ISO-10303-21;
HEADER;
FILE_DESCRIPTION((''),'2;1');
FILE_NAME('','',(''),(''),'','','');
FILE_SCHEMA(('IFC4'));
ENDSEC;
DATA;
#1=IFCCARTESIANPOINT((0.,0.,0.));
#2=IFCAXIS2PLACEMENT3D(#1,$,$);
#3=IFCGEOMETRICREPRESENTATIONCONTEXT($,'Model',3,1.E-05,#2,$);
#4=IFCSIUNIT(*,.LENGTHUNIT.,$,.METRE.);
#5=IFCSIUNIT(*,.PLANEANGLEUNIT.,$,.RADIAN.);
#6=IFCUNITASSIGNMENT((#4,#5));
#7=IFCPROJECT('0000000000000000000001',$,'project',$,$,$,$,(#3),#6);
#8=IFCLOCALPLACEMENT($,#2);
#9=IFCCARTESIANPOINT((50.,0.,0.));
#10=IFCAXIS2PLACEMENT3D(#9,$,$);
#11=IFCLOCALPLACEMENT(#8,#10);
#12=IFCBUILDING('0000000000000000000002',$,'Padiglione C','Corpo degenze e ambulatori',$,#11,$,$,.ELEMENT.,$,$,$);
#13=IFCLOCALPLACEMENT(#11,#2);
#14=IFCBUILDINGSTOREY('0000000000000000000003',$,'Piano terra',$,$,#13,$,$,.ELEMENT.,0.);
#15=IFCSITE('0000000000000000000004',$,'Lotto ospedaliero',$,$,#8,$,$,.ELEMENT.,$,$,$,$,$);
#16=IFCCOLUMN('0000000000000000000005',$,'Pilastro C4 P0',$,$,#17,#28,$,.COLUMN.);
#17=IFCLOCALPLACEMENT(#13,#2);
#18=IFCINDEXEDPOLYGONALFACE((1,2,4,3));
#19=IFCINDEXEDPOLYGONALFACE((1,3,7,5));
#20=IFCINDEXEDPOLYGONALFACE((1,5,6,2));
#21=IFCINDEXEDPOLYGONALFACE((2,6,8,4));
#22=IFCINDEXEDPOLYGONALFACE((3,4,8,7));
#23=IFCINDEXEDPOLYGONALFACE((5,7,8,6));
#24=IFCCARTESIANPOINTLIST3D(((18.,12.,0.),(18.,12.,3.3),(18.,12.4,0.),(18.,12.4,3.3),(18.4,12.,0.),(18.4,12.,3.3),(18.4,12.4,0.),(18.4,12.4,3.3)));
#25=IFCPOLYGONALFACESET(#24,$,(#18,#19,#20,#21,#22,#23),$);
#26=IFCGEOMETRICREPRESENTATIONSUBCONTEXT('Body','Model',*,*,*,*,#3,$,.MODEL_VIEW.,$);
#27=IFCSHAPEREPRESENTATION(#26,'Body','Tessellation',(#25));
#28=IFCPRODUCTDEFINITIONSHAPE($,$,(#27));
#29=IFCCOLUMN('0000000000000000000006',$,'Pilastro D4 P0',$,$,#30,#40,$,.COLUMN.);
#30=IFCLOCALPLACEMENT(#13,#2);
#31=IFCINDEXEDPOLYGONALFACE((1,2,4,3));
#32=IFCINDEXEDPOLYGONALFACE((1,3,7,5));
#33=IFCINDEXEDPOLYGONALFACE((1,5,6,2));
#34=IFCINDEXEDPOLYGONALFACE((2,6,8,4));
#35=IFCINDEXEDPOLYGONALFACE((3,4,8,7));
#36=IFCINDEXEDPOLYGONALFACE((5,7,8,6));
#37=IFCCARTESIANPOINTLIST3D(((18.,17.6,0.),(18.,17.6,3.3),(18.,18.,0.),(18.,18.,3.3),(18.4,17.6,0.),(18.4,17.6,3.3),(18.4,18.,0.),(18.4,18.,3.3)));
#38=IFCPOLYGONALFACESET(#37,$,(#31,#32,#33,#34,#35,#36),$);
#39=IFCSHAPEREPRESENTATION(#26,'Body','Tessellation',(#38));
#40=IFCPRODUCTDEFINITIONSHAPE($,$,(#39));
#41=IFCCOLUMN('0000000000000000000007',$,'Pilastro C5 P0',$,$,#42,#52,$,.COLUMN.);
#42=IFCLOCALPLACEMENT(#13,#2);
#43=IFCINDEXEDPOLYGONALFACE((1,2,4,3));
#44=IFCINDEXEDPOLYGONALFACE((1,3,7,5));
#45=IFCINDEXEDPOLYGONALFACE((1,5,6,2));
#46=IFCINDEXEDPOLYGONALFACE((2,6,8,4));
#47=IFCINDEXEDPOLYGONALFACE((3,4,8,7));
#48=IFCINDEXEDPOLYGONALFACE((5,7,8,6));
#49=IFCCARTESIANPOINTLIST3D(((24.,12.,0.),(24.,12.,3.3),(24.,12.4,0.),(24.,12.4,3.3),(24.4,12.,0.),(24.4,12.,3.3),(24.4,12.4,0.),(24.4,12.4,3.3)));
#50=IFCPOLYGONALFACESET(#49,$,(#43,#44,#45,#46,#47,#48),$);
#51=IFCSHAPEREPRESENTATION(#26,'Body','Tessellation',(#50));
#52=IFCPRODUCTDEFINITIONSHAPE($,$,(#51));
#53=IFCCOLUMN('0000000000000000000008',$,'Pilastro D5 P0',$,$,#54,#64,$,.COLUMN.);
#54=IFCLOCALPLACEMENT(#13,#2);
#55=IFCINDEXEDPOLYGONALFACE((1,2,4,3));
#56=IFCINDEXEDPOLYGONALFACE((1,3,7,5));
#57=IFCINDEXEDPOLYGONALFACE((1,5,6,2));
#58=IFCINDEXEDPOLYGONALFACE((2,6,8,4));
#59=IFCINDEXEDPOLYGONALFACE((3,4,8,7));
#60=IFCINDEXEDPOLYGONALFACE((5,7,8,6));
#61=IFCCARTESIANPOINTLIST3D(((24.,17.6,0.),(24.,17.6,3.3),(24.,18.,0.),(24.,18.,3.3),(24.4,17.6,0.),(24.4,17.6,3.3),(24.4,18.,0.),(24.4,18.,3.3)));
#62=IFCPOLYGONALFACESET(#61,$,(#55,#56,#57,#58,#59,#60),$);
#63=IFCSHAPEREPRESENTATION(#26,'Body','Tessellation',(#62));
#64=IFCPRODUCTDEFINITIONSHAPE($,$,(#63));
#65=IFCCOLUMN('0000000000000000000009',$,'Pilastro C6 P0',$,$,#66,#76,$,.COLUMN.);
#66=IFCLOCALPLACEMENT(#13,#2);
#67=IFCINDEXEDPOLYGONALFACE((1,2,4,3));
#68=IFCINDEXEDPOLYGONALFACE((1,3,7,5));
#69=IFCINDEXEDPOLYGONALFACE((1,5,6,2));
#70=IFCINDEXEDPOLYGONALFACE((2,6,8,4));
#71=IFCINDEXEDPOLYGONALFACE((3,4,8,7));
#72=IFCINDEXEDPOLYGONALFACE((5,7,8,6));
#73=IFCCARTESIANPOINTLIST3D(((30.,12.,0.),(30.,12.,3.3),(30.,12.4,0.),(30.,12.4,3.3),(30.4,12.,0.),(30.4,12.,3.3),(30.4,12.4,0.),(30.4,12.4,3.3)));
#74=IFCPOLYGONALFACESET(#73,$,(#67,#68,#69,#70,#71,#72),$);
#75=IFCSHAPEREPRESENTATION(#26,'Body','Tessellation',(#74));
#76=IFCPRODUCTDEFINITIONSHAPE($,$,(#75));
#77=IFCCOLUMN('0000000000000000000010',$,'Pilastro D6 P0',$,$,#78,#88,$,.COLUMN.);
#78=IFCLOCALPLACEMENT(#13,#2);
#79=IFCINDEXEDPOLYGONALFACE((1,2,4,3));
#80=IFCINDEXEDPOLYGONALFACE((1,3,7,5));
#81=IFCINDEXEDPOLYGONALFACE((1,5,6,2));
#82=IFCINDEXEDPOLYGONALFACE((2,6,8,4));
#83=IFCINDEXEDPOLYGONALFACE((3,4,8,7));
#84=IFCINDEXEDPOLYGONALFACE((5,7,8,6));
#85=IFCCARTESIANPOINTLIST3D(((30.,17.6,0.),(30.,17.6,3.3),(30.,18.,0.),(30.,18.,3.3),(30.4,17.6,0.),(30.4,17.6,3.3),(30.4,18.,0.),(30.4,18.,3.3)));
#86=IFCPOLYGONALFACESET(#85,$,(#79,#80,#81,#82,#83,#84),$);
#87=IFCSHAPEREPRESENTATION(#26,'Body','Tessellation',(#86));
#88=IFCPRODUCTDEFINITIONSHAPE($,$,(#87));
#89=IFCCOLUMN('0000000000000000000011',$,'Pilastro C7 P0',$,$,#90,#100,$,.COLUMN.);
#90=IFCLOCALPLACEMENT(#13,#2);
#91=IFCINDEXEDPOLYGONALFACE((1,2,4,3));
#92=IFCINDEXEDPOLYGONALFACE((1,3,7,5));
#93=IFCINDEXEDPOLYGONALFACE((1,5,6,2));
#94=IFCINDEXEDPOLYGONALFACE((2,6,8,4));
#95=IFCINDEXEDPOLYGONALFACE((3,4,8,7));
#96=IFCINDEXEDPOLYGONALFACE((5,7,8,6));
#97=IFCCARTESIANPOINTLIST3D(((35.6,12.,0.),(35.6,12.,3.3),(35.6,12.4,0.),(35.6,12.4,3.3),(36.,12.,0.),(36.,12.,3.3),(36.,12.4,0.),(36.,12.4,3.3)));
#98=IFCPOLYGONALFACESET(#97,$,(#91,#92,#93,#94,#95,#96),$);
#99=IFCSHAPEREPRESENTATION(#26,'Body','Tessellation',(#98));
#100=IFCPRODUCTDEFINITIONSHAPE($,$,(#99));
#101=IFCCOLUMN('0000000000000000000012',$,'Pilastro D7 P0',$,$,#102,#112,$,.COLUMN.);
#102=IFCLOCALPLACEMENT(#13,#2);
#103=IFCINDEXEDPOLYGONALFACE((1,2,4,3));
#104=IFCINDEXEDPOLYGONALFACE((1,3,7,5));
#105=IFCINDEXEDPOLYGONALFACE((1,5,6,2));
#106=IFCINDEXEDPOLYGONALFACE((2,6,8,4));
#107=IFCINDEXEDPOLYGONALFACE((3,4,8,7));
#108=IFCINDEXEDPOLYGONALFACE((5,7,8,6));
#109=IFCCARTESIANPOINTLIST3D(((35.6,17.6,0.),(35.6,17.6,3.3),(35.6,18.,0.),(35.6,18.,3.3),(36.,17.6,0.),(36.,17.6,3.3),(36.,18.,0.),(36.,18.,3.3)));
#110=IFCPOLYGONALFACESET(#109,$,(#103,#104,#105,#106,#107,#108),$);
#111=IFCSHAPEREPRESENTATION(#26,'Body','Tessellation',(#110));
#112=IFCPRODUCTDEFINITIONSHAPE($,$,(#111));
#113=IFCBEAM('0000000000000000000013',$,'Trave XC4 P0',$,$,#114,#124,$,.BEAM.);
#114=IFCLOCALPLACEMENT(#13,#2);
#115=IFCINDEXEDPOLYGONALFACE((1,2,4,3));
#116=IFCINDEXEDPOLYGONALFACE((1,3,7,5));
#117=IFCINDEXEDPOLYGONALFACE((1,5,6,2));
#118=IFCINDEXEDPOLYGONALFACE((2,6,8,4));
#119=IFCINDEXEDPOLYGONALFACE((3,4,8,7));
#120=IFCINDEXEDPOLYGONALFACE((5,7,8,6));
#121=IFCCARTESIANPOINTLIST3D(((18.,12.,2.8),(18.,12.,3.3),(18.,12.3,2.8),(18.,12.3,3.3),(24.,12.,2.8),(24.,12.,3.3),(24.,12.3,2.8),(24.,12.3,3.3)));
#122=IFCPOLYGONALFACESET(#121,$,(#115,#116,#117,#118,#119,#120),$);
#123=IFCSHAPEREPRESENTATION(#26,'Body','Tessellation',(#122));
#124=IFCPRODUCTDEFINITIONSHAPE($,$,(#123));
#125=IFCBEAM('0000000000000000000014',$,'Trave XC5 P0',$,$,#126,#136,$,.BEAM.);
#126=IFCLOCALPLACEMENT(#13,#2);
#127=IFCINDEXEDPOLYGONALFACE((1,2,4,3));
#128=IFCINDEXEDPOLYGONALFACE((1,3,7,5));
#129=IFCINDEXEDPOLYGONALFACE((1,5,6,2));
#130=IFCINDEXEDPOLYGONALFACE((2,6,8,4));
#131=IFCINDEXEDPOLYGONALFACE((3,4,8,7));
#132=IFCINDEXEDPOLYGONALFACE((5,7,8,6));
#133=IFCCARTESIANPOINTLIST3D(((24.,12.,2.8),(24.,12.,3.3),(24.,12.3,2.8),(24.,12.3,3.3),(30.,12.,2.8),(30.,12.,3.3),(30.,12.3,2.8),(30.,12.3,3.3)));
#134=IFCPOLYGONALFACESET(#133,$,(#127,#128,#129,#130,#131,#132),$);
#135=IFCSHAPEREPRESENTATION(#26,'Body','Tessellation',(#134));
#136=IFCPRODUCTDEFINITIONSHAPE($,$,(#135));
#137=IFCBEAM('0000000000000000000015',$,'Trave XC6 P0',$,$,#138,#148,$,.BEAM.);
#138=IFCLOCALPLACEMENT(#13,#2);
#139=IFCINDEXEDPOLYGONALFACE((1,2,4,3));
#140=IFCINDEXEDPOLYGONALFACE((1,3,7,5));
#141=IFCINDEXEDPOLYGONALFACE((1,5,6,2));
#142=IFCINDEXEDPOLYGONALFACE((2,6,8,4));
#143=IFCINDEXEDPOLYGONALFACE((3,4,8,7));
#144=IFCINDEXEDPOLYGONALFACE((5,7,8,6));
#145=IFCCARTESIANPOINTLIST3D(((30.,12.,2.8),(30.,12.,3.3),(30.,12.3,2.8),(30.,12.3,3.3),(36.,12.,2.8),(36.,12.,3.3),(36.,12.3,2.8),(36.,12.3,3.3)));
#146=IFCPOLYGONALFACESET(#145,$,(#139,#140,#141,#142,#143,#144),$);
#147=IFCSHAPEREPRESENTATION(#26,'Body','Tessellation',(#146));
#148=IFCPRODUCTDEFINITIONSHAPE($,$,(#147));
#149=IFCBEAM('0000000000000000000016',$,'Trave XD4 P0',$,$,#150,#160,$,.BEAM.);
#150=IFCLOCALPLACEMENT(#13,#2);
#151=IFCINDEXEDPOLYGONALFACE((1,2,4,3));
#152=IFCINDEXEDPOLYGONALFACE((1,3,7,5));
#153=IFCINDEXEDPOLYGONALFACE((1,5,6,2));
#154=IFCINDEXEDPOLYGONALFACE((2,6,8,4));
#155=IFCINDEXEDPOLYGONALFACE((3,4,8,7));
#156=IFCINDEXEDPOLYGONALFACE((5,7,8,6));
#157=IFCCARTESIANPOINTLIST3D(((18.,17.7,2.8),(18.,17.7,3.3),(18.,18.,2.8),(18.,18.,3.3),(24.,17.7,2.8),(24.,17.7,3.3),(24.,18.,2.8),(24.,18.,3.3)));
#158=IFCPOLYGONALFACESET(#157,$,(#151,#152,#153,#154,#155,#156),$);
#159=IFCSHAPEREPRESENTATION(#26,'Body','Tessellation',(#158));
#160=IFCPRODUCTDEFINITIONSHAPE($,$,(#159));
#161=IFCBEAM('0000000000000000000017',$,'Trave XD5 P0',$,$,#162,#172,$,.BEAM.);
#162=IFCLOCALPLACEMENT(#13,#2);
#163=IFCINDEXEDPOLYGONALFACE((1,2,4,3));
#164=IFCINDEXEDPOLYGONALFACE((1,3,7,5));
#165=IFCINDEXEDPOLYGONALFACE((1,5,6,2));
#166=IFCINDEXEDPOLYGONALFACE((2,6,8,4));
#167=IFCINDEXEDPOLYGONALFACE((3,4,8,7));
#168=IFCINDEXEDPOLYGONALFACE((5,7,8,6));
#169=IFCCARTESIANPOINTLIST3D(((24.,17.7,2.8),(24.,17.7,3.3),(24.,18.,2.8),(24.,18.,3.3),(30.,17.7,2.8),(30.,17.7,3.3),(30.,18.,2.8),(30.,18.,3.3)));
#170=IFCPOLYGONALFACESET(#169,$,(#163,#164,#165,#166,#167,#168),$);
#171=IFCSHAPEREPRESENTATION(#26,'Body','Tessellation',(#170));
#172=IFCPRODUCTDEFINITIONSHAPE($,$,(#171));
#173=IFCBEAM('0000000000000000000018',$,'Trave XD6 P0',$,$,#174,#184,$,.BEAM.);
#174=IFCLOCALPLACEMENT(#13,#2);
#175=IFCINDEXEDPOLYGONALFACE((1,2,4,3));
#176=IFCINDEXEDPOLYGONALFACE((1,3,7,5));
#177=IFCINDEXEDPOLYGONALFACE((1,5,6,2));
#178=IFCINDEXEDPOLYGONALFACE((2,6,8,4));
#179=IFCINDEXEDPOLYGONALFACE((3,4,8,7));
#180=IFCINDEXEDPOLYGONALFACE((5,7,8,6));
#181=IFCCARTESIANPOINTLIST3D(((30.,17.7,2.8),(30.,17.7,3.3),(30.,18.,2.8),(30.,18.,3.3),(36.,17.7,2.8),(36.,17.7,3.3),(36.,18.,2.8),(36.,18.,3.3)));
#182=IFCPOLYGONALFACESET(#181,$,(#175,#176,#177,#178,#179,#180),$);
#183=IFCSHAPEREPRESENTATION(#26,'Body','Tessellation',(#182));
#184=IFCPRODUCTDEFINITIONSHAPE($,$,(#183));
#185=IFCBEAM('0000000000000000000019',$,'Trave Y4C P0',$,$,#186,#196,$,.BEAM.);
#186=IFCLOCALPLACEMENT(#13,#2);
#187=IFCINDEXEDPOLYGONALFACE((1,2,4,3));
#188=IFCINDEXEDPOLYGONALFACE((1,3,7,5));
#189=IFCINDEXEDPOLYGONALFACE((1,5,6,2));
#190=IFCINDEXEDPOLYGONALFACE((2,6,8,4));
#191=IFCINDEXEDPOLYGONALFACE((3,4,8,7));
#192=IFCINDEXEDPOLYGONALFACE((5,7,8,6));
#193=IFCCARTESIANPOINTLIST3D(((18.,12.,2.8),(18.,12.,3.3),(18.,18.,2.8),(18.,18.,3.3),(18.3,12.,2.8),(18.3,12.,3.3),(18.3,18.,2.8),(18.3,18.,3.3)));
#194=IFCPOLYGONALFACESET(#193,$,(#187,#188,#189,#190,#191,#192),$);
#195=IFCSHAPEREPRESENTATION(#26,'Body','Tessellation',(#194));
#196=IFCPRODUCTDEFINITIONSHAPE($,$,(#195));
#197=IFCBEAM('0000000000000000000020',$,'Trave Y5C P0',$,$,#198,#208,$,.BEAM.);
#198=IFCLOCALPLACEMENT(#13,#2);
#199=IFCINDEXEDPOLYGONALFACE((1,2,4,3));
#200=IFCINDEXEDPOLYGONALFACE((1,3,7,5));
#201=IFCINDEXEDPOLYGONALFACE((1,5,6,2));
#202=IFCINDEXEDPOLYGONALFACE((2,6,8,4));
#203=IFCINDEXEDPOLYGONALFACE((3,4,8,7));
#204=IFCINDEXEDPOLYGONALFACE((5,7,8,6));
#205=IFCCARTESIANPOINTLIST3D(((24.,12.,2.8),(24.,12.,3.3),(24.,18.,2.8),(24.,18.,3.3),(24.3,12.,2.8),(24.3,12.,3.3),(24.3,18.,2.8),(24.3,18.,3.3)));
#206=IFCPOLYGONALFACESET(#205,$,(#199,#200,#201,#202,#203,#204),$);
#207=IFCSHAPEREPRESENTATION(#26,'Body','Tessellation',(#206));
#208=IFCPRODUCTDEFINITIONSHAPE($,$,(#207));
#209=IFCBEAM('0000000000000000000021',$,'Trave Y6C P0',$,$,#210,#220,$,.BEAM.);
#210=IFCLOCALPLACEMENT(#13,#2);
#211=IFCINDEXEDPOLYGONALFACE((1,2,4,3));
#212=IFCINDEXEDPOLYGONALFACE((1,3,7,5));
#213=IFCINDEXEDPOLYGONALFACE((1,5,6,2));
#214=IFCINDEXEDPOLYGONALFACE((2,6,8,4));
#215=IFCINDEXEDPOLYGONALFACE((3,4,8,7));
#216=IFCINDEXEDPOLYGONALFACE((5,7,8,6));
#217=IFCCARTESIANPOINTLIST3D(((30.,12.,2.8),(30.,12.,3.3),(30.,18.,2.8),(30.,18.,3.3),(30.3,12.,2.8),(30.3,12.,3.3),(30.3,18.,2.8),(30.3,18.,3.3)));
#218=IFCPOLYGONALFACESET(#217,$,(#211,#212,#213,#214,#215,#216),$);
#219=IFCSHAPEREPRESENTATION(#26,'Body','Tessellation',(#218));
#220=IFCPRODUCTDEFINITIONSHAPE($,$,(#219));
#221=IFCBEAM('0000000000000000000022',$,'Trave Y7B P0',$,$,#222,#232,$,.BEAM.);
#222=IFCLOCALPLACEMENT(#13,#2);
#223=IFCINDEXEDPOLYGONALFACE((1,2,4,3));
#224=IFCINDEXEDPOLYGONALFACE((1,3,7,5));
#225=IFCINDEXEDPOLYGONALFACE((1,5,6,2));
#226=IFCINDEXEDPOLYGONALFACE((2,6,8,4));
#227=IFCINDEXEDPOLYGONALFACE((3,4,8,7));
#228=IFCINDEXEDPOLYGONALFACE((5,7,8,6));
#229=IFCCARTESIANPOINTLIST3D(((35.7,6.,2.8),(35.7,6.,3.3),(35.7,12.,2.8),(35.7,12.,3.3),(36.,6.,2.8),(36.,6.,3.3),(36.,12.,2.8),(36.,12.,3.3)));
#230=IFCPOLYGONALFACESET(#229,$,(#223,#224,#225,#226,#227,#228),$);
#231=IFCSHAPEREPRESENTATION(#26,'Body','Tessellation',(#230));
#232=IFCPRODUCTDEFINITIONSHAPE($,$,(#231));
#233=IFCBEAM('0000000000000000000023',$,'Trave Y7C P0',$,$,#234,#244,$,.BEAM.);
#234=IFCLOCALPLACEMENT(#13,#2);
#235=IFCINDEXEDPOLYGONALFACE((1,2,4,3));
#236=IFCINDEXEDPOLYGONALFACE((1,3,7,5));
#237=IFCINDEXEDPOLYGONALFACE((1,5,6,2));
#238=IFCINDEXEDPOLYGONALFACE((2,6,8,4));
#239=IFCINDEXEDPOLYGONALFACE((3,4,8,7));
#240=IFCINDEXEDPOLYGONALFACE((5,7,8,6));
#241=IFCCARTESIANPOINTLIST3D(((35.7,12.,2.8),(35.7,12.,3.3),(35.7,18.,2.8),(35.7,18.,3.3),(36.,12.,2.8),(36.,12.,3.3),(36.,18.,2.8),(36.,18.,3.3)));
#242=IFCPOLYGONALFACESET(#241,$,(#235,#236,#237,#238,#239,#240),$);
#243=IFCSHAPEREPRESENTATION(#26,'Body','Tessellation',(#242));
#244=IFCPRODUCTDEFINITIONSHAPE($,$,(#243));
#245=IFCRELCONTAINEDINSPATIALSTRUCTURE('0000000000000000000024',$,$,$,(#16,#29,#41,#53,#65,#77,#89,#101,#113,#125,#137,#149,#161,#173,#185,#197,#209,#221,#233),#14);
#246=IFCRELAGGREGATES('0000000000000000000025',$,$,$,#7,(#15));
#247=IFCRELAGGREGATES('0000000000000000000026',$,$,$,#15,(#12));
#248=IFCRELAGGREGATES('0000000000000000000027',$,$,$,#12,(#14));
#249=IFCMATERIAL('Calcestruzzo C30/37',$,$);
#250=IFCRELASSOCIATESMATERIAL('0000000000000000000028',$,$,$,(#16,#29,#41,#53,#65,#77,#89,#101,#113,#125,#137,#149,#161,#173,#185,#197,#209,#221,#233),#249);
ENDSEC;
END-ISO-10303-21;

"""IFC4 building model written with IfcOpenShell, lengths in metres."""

from ifc_helpers import new_model, si_unit, frame, frame_2d, origin, place, context, subcontext, project, spatial, rectangle, extrude, material, element, save


model = new_model("IFC4")

# Units and contexts
model_context = context("Model", 3, precision=1e-05, world=origin())
body_context = subcontext(model_context, "Body", "Model", "MODEL_VIEW")
ifc_project = project(units=[si_unit("LENGTHUNIT", "METRE"), si_unit("PLANEANGLEUNIT", "RADIAN")], contexts=[model_context])

# Site, building, storey
site_placement = place(None, origin())
site = spatial("IfcSite", under=ifc_project, at=site_placement, Name="Lotto ospedaliero", CompositionType="ELEMENT")
building_placement = place(site_placement, frame((50.0, 0.0, 0.0)))
building = spatial("IfcBuilding", under=site, at=building_placement, Name="Padiglione C", Description="Corpo degenze e ambulatori", CompositionType="ELEMENT")
storey_placement = place(building_placement, origin())
storey = spatial("IfcBuildingStorey", under=building, at=storey_placement, Name="Piano terra", CompositionType="ELEMENT", Elevation=0.0)

# Columns
ifc_material_1 = material(Name="Calcestruzzo C30/37")
for number, where, name in (
    (1, (18.0, 12.0, 0.0), "Pilastro C4 P0"),
    (2, (18.0, 17.6, 0.0), "Pilastro D4 P0"),
    (3, (24.0, 12.0, 0.0), "Pilastro C5 P0"),
    (4, (24.0, 17.6, 0.0), "Pilastro D5 P0"),
    (5, (30.0, 12.0, 0.0), "Pilastro C6 P0"),
    (6, (30.0, 17.6, 0.0), "Pilastro D6 P0"),
    (7, (35.6, 12.0, 0.0), "Pilastro C7 P0"),
    (8, (35.6, 17.6, 0.0), "Pilastro D7 P0"),
):
    element("IfcColumn", number, at=place(storey_placement, frame(where)), inside=storey, material=ifc_material_1, Name=name, PredefinedType="COLUMN", context=body_context, shape_type="SweptSolid", body=[
        extrude(rectangle(XDim=0.4, YDim=0.4, at=frame_2d((0.2, 0.2))), origin(), (0.0, 0.0, 1.0), 3.3),
    ])

# Beams
for number, where, name in (
    (9, (18.0, 12.0, 2.8), "Trave XC4 P0"),
    (10, (24.0, 12.0, 2.8), "Trave XC5 P0"),
    (11, (30.0, 12.0, 2.8), "Trave XC6 P0"),
    (12, (18.0, 17.7, 2.8), "Trave XD4 P0"),
    (13, (24.0, 17.7, 2.8), "Trave XD5 P0"),
    (14, (30.0, 17.7, 2.8), "Trave XD6 P0"),
):
    element("IfcBeam", number, at=place(storey_placement, frame(where)), inside=storey, material=ifc_material_1, Name=name, PredefinedType="BEAM", context=body_context, shape_type="SweptSolid", body=[
        extrude(rectangle(XDim=6.0, YDim=0.3, at=frame_2d((3.0, 0.15))), origin(), (0.0, 0.0, 1.0), 0.5),
    ])
for number, where, name in (
    (15, (18.0, 12.0, 2.8), "Trave Y4C P0"),
    (16, (24.0, 12.0, 2.8), "Trave Y5C P0"),
    (17, (30.0, 12.0, 2.8), "Trave Y6C P0"),
    (18, (35.7, 6.0, 2.8), "Trave Y7B P0"),
    (19, (35.7, 12.0, 2.8), "Trave Y7C P0"),
):
    element("IfcBeam", number, at=place(storey_placement, frame(where)), inside=storey, material=ifc_material_1, Name=name, PredefinedType="BEAM", context=body_context, shape_type="SweptSolid", body=[
        extrude(rectangle(XDim=0.3, YDim=6.0, at=frame_2d((0.15, 3.0))), origin(), (0.0, 0.0, 1.0), 0.5),
    ])

save(model, "model.ifc")
